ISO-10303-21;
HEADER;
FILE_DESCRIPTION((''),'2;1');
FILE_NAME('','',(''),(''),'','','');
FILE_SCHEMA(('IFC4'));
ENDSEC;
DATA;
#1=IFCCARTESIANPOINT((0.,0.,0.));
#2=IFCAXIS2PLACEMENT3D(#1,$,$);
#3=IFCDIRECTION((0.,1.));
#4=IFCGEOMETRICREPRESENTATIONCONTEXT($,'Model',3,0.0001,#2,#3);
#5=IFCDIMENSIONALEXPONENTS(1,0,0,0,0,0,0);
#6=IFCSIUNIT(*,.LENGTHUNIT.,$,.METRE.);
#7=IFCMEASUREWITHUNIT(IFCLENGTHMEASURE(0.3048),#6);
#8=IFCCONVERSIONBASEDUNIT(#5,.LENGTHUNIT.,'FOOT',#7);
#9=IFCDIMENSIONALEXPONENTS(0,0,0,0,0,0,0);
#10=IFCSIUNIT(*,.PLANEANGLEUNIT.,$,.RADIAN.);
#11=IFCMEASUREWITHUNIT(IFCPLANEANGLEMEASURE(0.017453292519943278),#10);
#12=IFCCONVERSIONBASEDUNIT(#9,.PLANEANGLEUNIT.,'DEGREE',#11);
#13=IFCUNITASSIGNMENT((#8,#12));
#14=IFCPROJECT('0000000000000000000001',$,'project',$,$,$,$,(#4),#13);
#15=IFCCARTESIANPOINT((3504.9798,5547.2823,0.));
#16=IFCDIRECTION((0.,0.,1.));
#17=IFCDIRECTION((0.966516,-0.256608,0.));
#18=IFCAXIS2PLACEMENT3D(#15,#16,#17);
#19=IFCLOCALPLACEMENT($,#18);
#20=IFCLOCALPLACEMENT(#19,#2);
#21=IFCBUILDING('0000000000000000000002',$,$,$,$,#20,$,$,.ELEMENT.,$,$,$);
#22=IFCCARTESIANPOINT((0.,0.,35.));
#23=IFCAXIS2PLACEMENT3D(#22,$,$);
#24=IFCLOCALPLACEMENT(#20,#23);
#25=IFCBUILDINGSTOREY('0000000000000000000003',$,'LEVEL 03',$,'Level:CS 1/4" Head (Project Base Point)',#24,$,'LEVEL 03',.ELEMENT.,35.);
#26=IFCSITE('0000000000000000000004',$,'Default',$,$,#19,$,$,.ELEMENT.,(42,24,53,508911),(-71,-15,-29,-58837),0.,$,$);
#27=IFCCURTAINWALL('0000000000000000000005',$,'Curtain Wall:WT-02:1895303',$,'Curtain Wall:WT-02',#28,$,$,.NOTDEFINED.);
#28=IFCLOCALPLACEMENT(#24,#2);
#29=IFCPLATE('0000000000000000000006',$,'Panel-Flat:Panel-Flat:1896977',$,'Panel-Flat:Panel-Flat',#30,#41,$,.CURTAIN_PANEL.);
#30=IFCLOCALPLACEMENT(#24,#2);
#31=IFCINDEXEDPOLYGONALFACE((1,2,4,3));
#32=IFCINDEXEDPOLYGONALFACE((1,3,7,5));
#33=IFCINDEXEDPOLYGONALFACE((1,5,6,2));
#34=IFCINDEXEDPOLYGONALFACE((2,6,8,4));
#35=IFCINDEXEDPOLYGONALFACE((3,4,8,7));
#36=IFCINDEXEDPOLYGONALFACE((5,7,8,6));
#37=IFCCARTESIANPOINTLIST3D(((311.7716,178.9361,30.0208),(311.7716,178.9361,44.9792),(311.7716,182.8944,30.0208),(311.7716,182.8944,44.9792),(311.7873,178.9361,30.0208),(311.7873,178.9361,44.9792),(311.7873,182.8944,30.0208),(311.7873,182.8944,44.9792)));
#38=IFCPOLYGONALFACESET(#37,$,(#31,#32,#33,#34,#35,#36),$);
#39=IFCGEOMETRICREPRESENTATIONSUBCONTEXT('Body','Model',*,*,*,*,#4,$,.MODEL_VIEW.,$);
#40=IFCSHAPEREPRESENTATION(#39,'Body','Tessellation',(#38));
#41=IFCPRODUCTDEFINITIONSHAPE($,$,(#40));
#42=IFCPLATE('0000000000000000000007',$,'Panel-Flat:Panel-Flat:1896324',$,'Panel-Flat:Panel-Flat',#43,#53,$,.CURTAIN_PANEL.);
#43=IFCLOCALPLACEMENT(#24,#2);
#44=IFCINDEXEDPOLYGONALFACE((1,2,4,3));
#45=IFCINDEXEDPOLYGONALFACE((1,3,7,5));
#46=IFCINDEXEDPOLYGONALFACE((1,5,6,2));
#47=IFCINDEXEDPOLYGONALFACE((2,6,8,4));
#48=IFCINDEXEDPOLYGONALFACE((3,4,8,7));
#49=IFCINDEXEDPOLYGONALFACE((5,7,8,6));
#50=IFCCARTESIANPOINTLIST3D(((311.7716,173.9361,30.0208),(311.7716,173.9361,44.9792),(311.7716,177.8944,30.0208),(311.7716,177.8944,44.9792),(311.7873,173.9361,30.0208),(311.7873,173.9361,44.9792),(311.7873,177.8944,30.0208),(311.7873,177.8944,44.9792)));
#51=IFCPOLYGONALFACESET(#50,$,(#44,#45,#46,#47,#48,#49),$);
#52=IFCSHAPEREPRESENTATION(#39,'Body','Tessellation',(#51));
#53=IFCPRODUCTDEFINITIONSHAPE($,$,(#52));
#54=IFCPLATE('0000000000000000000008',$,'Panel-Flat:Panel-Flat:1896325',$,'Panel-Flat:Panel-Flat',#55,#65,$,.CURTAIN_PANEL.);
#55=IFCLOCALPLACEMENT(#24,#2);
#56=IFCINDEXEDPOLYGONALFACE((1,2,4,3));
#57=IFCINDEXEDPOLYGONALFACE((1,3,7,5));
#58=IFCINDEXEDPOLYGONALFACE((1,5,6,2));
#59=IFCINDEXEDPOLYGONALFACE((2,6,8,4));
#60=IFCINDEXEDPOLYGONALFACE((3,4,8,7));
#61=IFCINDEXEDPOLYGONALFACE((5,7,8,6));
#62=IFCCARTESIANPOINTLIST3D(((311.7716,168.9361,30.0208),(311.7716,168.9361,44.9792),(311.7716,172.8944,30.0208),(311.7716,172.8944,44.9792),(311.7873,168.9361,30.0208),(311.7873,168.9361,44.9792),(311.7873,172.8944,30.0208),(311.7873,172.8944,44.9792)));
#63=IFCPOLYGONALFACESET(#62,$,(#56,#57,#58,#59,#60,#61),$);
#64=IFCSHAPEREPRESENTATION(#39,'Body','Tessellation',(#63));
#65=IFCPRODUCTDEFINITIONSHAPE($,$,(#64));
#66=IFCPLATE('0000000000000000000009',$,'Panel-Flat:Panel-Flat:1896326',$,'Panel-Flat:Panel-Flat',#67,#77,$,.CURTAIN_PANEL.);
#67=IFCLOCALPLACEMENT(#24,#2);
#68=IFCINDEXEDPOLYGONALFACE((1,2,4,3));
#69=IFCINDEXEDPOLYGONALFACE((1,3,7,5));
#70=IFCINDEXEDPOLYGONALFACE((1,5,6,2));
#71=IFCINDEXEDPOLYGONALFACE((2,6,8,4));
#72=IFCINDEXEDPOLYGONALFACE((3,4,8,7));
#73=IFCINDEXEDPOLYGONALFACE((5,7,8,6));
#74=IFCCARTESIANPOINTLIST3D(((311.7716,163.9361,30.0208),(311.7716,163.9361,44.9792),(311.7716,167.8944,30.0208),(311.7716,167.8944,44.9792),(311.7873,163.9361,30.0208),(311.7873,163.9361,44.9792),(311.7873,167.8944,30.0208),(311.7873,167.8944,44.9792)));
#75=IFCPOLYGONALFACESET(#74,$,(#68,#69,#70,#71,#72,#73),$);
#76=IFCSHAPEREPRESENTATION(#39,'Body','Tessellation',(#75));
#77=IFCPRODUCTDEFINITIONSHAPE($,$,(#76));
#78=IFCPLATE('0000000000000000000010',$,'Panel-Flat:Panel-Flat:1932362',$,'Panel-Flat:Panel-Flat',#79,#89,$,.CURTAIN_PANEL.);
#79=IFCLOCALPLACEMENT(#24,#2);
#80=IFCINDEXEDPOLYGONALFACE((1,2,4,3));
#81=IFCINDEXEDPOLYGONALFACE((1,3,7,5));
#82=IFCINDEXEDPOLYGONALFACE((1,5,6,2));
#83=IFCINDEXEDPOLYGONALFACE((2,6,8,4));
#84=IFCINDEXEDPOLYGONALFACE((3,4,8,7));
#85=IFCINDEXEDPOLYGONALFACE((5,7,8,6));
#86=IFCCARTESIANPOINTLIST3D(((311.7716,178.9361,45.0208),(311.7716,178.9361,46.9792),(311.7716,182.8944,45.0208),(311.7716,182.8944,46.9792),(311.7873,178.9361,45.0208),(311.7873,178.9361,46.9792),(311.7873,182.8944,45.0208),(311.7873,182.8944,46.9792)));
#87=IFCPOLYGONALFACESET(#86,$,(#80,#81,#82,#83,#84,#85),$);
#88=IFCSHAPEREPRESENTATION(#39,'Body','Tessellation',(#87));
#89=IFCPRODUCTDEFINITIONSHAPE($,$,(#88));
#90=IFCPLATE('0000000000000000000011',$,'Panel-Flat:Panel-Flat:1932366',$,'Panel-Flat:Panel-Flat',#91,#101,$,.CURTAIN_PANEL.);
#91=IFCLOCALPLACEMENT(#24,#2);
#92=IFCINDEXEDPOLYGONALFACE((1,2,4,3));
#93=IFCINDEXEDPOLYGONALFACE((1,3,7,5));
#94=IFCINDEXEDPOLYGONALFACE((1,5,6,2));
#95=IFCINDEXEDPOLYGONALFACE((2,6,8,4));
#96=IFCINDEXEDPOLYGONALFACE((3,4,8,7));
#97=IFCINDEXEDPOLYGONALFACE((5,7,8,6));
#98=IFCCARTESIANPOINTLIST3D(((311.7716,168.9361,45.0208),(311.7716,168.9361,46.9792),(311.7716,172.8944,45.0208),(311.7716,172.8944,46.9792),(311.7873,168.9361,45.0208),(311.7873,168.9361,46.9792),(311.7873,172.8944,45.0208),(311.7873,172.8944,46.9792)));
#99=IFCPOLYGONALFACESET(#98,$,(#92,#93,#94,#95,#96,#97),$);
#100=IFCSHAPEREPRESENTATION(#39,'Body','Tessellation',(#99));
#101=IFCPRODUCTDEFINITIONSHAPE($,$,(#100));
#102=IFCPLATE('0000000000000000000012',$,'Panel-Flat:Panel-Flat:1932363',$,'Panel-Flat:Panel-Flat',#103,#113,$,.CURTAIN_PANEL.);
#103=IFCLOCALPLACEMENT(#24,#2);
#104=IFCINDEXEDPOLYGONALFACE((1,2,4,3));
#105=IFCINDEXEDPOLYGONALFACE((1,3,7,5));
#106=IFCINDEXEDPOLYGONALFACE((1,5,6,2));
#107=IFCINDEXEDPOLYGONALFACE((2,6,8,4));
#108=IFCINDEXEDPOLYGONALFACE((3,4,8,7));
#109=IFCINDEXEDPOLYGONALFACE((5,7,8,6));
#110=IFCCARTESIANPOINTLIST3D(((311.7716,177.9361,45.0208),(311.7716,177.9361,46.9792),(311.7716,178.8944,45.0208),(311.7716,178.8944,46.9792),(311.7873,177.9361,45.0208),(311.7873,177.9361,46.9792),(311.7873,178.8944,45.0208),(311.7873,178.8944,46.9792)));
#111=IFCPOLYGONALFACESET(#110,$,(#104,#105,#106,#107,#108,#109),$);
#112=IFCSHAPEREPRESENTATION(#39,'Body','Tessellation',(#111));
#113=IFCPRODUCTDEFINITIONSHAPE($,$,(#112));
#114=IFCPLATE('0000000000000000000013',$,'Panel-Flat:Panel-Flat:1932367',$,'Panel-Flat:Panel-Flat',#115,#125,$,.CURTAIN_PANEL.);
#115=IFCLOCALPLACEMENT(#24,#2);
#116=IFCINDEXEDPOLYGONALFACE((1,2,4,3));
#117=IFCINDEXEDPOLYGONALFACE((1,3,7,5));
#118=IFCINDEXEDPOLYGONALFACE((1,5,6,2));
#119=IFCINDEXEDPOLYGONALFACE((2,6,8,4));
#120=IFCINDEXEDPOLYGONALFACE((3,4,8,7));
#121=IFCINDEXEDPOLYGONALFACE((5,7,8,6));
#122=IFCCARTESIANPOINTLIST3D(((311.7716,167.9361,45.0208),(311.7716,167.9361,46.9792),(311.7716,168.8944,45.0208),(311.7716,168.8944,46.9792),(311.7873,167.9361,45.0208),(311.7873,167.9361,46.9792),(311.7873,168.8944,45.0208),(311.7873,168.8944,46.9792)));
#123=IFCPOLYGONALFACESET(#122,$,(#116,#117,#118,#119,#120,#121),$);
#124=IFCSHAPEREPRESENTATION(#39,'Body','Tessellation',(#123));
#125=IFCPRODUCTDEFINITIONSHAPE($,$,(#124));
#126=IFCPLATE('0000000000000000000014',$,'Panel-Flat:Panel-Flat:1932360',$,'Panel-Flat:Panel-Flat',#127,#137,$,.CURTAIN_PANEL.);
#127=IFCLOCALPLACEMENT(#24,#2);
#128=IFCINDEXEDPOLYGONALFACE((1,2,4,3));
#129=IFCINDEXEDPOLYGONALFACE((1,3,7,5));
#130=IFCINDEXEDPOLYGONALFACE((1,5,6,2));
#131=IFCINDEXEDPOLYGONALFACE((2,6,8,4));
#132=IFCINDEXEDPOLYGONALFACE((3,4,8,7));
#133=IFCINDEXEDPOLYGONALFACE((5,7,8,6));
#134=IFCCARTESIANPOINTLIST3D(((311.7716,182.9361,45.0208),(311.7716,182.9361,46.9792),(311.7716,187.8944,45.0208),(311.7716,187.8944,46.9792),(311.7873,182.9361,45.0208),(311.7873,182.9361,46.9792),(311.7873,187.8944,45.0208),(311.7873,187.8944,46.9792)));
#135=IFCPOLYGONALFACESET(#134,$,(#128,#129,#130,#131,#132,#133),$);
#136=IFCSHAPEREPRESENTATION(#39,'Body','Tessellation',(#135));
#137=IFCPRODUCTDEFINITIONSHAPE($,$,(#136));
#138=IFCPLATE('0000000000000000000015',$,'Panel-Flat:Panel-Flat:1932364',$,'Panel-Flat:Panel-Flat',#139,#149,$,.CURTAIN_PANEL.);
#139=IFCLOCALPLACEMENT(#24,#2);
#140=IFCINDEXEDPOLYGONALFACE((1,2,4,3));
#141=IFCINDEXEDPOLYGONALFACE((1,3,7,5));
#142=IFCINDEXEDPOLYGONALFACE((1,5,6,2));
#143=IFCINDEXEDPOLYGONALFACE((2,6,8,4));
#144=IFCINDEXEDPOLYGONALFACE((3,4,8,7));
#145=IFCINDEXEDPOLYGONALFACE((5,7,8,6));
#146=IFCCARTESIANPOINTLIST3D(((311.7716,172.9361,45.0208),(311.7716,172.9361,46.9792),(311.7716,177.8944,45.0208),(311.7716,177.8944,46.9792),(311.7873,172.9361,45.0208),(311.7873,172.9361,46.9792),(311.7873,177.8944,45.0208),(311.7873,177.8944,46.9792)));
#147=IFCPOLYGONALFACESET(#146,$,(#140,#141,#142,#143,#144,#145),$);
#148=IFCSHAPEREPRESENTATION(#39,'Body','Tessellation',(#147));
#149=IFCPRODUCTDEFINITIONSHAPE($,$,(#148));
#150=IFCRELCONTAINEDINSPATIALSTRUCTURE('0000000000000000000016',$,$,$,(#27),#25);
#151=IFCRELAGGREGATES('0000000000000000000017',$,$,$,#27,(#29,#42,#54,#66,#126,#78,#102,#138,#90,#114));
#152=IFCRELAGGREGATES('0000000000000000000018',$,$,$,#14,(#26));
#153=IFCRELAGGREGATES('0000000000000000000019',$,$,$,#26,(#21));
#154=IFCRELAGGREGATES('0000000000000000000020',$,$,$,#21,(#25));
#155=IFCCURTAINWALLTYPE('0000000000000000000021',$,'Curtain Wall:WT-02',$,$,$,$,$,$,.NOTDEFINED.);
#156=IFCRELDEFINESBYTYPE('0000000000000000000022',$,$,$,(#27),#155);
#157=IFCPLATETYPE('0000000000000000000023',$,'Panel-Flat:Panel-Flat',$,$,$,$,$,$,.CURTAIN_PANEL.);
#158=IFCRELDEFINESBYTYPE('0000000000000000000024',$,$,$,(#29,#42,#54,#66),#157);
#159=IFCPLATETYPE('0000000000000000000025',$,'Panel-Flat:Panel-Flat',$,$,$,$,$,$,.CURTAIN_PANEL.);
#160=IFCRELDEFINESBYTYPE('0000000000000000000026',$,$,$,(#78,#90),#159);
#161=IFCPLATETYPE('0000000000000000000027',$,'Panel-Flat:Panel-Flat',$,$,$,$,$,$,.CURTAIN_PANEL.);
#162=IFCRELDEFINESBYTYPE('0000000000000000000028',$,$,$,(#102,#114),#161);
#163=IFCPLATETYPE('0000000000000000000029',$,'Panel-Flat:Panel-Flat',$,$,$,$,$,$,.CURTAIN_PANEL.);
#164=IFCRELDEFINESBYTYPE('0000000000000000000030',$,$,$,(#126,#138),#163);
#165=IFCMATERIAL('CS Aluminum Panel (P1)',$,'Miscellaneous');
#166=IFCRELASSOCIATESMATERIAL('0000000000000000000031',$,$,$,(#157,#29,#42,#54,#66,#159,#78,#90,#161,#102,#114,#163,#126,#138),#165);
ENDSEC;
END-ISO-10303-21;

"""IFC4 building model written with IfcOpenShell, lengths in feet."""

from ifc_helpers import new_model, entity, si_unit, converted_unit, direction, frame, origin, place, context, subcontext, project, spatial, indexed_curve, outline, extrude, source, transform, mapped, material, type_object, type_shapes, element, aggregate, save


model = new_model("IFC4")

# Units and contexts
model_context = context("Model", 3, precision=0.0001, world=origin(), true_north=direction((0.0, 1.0)))
body_context = subcontext(model_context, "Body", "Model", "MODEL_VIEW")
ifc_project = project(units=[converted_unit("LENGTHUNIT", "FOOT", entity("IfcLengthMeasure", 0.3048), si_unit("LENGTHUNIT", "METRE"), dimensions=[1, 0, 0, 0, 0, 0, 0]), converted_unit("PLANEANGLEUNIT", "DEGREE", entity("IfcPlaneAngleMeasure", 0.017453292519943278), si_unit("PLANEANGLEUNIT", "RADIAN"), dimensions=[0, 0, 0, 0, 0, 0, 0])], contexts=[model_context])

# Site, building, storey
site_placement = place(None, frame((3504.9798, 5547.2823, 0.0), z_axis=(0.0, 0.0, 1.0), x_axis=(0.966516, -0.256608, 0.0)))
site = spatial("IfcSite", under=ifc_project, at=site_placement, Name="Default", CompositionType="ELEMENT", RefLatitude=(42, 24, 53, 508911), RefLongitude=(-71, -15, -29, -58837), RefElevation=0.0)
building_placement = place(site_placement, origin())
building = spatial("IfcBuilding", under=site, at=building_placement, CompositionType="ELEMENT")
storey_placement = place(building_placement, frame((0.0, 0.0, 35.0)))
storey = spatial("IfcBuildingStorey", under=building, at=storey_placement, Name="LEVEL 03", ObjectType="Level:CS 1/4\" Head (Project Base Point)", LongName="LEVEL 03", CompositionType="ELEMENT", Elevation=35.0)

# Curtain wall, plates
curtain_wall_type = type_object("IfcCurtainWallType", Name="Curtain Wall:WT-02", PredefinedType="NOTDEFINED")
curtain_wall_placement = place(storey_placement, frame((0.0, 0.0, -35.0)))
curtain_wall = element("IfcCurtainWall", 1, at=curtain_wall_placement, inside=storey, type_object=curtain_wall_type, Name="Curtain Wall:WT-02:1895303", ObjectType="Curtain Wall:WT-02", PredefinedType="NOTDEFINED")
ifc_material = material(Name="CS Aluminum Panel (P1)", Category="Miscellaneous")
plate_type_1 = type_object("IfcPlateType", Name="Panel-Flat:Panel-Flat", PredefinedType="CURTAIN_PANEL", material=ifc_material)
shared_shape_1 = source(origin(), body_context, "Body", "SweptSolid", [
    extrude(outline(indexed_curve([(-0.0078, -1.9792), (0.0078, -1.9792), (0.0078, 1.9792), (-0.0078, 1.9792), (-0.0078, -1.9792)], self_intersect=False)), frame((0.0, -0.0078, 0.0208), z_axis=(0.0, 0.0, 1.0), x_axis=(0.0, -1.0, 0.0)), (0.0, 0.0, 1.0), 14.9583),
])
type_shapes(plate_type_1, [shared_shape_1])
plate_1_placement = place(curtain_wall_placement, frame((311.7873, 180.9153, 65.0), z_axis=(0.0, 0.0, 1.0), x_axis=(0.0, -1.0, 0.0)))
plate_1 = element("IfcPlate", 2, at=plate_1_placement, type_object=plate_type_1, material=ifc_material, Name="Panel-Flat:Panel-Flat:1896977", ObjectType="Panel-Flat:Panel-Flat", PredefinedType="CURTAIN_PANEL", context=body_context, shape_type="MappedRepresentation", body=[
    mapped(shared_shape_1, transform((0.0, 0.0, 0.0), scale=1.0)),
])
plate_2_placement = place(curtain_wall_placement, frame((311.7873, 175.9153, 65.0), z_axis=(0.0, 0.0, 1.0), x_axis=(0.0, -1.0, 0.0)))
plate_2 = element("IfcPlate", 3, at=plate_2_placement, type_object=plate_type_1, material=ifc_material, Name="Panel-Flat:Panel-Flat:1896324", ObjectType="Panel-Flat:Panel-Flat", PredefinedType="CURTAIN_PANEL", context=body_context, shape_type="MappedRepresentation", body=[
    mapped(shared_shape_1, transform((0.0, 0.0, 0.0), scale=1.0)),
])
plate_3_placement = place(curtain_wall_placement, frame((311.7873, 170.9153, 65.0), z_axis=(0.0, 0.0, 1.0), x_axis=(0.0, -1.0, 0.0)))
plate_3 = element("IfcPlate", 4, at=plate_3_placement, type_object=plate_type_1, material=ifc_material, Name="Panel-Flat:Panel-Flat:1896325", ObjectType="Panel-Flat:Panel-Flat", PredefinedType="CURTAIN_PANEL", context=body_context, shape_type="MappedRepresentation", body=[
    mapped(shared_shape_1, transform((0.0, 0.0, 0.0), scale=1.0)),
])
plate_4_placement = place(curtain_wall_placement, frame((311.7873, 165.9153, 65.0), z_axis=(0.0, 0.0, 1.0), x_axis=(0.0, -1.0, 0.0)))
plate_4 = element("IfcPlate", 5, at=plate_4_placement, type_object=plate_type_1, material=ifc_material, Name="Panel-Flat:Panel-Flat:1896326", ObjectType="Panel-Flat:Panel-Flat", PredefinedType="CURTAIN_PANEL", context=body_context, shape_type="MappedRepresentation", body=[
    mapped(shared_shape_1, transform((0.0, 0.0, 0.0), scale=1.0)),
])
plate_type_2 = type_object("IfcPlateType", Name="Panel-Flat:Panel-Flat", PredefinedType="CURTAIN_PANEL", material=ifc_material)
shared_shape_2 = source(origin(), body_context, "Body", "SweptSolid", [
    extrude(outline(indexed_curve([(-0.0078, -1.9792), (0.0078, -1.9792), (0.0078, 1.9792), (-0.0078, 1.9792), (-0.0078, -1.9792)], self_intersect=False)), frame((0.0, -0.0078, 0.0208), z_axis=(0.0, 0.0, 1.0), x_axis=(0.0, -1.0, 0.0)), (0.0, 0.0, 1.0), 1.9583),
])
type_shapes(plate_type_2, [shared_shape_2])
plate_5_placement = place(curtain_wall_placement, frame((311.7873, 180.9153, 80.0), z_axis=(0.0, 0.0, 1.0), x_axis=(0.0, -1.0, 0.0)))
plate_5 = element("IfcPlate", 6, at=plate_5_placement, type_object=plate_type_2, material=ifc_material, Name="Panel-Flat:Panel-Flat:1932362", ObjectType="Panel-Flat:Panel-Flat", PredefinedType="CURTAIN_PANEL", context=body_context, shape_type="MappedRepresentation", body=[
    mapped(shared_shape_2, transform((0.0, 0.0, 0.0), scale=1.0)),
])
plate_6_placement = place(curtain_wall_placement, frame((311.7873, 170.9153, 80.0), z_axis=(0.0, 0.0, 1.0), x_axis=(0.0, -1.0, 0.0)))
plate_6 = element("IfcPlate", 7, at=plate_6_placement, type_object=plate_type_2, material=ifc_material, Name="Panel-Flat:Panel-Flat:1932366", ObjectType="Panel-Flat:Panel-Flat", PredefinedType="CURTAIN_PANEL", context=body_context, shape_type="MappedRepresentation", body=[
    mapped(shared_shape_2, transform((0.0, 0.0, 0.0), scale=1.0)),
])
plate_type_3 = type_object("IfcPlateType", Name="Panel-Flat:Panel-Flat", PredefinedType="CURTAIN_PANEL", material=ifc_material)
shared_shape_3 = source(origin(), body_context, "Body", "SweptSolid", [
    extrude(outline(indexed_curve([(-0.0078, -0.4792), (0.0078, -0.4792), (0.0078, 0.4792), (-0.0078, 0.4792), (-0.0078, -0.4792)], self_intersect=False)), frame((0.0, -0.0078, 0.0208), z_axis=(0.0, 0.0, 1.0), x_axis=(0.0, -1.0, 0.0)), (0.0, 0.0, 1.0), 1.9583),
])
type_shapes(plate_type_3, [shared_shape_3])
plate_7_placement = place(curtain_wall_placement, frame((311.7873, 178.4153, 80.0), z_axis=(0.0, 0.0, 1.0), x_axis=(0.0, -1.0, 0.0)))
plate_7 = element("IfcPlate", 8, at=plate_7_placement, type_object=plate_type_3, material=ifc_material, Name="Panel-Flat:Panel-Flat:1932363", ObjectType="Panel-Flat:Panel-Flat", PredefinedType="CURTAIN_PANEL", context=body_context, shape_type="MappedRepresentation", body=[
    mapped(shared_shape_3, transform((0.0, 0.0, 0.0), scale=1.0)),
])
plate_8_placement = place(curtain_wall_placement, frame((311.7873, 168.4153, 80.0), z_axis=(0.0, 0.0, 1.0), x_axis=(0.0, -1.0, 0.0)))
plate_8 = element("IfcPlate", 9, at=plate_8_placement, type_object=plate_type_3, material=ifc_material, Name="Panel-Flat:Panel-Flat:1932367", ObjectType="Panel-Flat:Panel-Flat", PredefinedType="CURTAIN_PANEL", context=body_context, shape_type="MappedRepresentation", body=[
    mapped(shared_shape_3, transform((0.0, 0.0, 0.0), scale=1.0)),
])
plate_type_4 = type_object("IfcPlateType", Name="Panel-Flat:Panel-Flat", PredefinedType="CURTAIN_PANEL", material=ifc_material)
shared_shape_4 = source(origin(), body_context, "Body", "SweptSolid", [
    extrude(outline(indexed_curve([(-0.0078, -2.4792), (0.0078, -2.4792), (0.0078, 2.4792), (-0.0078, 2.4792), (-0.0078, -2.4792)], self_intersect=False)), frame((0.0, -0.0078, 0.0208), z_axis=(0.0, 0.0, 1.0), x_axis=(0.0, -1.0, 0.0)), (0.0, 0.0, 1.0), 1.9583),
])
type_shapes(plate_type_4, [shared_shape_4])
plate_9_placement = place(curtain_wall_placement, frame((311.7873, 185.4153, 80.0), z_axis=(0.0, 0.0, 1.0), x_axis=(0.0, -1.0, 0.0)))
plate_9 = element("IfcPlate", 10, at=plate_9_placement, type_object=plate_type_4, material=ifc_material, Name="Panel-Flat:Panel-Flat:1932360", ObjectType="Panel-Flat:Panel-Flat", PredefinedType="CURTAIN_PANEL", context=body_context, shape_type="MappedRepresentation", body=[
    mapped(shared_shape_4, transform((0.0, 0.0, 0.0), scale=1.0)),
])
plate_10_placement = place(curtain_wall_placement, frame((311.7873, 175.4153, 80.0), z_axis=(0.0, 0.0, 1.0), x_axis=(0.0, -1.0, 0.0)))
plate_10 = element("IfcPlate", 11, at=plate_10_placement, type_object=plate_type_4, material=ifc_material, Name="Panel-Flat:Panel-Flat:1932364", ObjectType="Panel-Flat:Panel-Flat", PredefinedType="CURTAIN_PANEL", context=body_context, shape_type="MappedRepresentation", body=[
    mapped(shared_shape_4, transform((0.0, 0.0, 0.0), scale=1.0)),
])
aggregate(curtain_wall, [plate_1, plate_2, plate_3, plate_4, plate_9, plate_5, plate_7, plate_10, plate_6, plate_8])

save(model, "model.ifc")
